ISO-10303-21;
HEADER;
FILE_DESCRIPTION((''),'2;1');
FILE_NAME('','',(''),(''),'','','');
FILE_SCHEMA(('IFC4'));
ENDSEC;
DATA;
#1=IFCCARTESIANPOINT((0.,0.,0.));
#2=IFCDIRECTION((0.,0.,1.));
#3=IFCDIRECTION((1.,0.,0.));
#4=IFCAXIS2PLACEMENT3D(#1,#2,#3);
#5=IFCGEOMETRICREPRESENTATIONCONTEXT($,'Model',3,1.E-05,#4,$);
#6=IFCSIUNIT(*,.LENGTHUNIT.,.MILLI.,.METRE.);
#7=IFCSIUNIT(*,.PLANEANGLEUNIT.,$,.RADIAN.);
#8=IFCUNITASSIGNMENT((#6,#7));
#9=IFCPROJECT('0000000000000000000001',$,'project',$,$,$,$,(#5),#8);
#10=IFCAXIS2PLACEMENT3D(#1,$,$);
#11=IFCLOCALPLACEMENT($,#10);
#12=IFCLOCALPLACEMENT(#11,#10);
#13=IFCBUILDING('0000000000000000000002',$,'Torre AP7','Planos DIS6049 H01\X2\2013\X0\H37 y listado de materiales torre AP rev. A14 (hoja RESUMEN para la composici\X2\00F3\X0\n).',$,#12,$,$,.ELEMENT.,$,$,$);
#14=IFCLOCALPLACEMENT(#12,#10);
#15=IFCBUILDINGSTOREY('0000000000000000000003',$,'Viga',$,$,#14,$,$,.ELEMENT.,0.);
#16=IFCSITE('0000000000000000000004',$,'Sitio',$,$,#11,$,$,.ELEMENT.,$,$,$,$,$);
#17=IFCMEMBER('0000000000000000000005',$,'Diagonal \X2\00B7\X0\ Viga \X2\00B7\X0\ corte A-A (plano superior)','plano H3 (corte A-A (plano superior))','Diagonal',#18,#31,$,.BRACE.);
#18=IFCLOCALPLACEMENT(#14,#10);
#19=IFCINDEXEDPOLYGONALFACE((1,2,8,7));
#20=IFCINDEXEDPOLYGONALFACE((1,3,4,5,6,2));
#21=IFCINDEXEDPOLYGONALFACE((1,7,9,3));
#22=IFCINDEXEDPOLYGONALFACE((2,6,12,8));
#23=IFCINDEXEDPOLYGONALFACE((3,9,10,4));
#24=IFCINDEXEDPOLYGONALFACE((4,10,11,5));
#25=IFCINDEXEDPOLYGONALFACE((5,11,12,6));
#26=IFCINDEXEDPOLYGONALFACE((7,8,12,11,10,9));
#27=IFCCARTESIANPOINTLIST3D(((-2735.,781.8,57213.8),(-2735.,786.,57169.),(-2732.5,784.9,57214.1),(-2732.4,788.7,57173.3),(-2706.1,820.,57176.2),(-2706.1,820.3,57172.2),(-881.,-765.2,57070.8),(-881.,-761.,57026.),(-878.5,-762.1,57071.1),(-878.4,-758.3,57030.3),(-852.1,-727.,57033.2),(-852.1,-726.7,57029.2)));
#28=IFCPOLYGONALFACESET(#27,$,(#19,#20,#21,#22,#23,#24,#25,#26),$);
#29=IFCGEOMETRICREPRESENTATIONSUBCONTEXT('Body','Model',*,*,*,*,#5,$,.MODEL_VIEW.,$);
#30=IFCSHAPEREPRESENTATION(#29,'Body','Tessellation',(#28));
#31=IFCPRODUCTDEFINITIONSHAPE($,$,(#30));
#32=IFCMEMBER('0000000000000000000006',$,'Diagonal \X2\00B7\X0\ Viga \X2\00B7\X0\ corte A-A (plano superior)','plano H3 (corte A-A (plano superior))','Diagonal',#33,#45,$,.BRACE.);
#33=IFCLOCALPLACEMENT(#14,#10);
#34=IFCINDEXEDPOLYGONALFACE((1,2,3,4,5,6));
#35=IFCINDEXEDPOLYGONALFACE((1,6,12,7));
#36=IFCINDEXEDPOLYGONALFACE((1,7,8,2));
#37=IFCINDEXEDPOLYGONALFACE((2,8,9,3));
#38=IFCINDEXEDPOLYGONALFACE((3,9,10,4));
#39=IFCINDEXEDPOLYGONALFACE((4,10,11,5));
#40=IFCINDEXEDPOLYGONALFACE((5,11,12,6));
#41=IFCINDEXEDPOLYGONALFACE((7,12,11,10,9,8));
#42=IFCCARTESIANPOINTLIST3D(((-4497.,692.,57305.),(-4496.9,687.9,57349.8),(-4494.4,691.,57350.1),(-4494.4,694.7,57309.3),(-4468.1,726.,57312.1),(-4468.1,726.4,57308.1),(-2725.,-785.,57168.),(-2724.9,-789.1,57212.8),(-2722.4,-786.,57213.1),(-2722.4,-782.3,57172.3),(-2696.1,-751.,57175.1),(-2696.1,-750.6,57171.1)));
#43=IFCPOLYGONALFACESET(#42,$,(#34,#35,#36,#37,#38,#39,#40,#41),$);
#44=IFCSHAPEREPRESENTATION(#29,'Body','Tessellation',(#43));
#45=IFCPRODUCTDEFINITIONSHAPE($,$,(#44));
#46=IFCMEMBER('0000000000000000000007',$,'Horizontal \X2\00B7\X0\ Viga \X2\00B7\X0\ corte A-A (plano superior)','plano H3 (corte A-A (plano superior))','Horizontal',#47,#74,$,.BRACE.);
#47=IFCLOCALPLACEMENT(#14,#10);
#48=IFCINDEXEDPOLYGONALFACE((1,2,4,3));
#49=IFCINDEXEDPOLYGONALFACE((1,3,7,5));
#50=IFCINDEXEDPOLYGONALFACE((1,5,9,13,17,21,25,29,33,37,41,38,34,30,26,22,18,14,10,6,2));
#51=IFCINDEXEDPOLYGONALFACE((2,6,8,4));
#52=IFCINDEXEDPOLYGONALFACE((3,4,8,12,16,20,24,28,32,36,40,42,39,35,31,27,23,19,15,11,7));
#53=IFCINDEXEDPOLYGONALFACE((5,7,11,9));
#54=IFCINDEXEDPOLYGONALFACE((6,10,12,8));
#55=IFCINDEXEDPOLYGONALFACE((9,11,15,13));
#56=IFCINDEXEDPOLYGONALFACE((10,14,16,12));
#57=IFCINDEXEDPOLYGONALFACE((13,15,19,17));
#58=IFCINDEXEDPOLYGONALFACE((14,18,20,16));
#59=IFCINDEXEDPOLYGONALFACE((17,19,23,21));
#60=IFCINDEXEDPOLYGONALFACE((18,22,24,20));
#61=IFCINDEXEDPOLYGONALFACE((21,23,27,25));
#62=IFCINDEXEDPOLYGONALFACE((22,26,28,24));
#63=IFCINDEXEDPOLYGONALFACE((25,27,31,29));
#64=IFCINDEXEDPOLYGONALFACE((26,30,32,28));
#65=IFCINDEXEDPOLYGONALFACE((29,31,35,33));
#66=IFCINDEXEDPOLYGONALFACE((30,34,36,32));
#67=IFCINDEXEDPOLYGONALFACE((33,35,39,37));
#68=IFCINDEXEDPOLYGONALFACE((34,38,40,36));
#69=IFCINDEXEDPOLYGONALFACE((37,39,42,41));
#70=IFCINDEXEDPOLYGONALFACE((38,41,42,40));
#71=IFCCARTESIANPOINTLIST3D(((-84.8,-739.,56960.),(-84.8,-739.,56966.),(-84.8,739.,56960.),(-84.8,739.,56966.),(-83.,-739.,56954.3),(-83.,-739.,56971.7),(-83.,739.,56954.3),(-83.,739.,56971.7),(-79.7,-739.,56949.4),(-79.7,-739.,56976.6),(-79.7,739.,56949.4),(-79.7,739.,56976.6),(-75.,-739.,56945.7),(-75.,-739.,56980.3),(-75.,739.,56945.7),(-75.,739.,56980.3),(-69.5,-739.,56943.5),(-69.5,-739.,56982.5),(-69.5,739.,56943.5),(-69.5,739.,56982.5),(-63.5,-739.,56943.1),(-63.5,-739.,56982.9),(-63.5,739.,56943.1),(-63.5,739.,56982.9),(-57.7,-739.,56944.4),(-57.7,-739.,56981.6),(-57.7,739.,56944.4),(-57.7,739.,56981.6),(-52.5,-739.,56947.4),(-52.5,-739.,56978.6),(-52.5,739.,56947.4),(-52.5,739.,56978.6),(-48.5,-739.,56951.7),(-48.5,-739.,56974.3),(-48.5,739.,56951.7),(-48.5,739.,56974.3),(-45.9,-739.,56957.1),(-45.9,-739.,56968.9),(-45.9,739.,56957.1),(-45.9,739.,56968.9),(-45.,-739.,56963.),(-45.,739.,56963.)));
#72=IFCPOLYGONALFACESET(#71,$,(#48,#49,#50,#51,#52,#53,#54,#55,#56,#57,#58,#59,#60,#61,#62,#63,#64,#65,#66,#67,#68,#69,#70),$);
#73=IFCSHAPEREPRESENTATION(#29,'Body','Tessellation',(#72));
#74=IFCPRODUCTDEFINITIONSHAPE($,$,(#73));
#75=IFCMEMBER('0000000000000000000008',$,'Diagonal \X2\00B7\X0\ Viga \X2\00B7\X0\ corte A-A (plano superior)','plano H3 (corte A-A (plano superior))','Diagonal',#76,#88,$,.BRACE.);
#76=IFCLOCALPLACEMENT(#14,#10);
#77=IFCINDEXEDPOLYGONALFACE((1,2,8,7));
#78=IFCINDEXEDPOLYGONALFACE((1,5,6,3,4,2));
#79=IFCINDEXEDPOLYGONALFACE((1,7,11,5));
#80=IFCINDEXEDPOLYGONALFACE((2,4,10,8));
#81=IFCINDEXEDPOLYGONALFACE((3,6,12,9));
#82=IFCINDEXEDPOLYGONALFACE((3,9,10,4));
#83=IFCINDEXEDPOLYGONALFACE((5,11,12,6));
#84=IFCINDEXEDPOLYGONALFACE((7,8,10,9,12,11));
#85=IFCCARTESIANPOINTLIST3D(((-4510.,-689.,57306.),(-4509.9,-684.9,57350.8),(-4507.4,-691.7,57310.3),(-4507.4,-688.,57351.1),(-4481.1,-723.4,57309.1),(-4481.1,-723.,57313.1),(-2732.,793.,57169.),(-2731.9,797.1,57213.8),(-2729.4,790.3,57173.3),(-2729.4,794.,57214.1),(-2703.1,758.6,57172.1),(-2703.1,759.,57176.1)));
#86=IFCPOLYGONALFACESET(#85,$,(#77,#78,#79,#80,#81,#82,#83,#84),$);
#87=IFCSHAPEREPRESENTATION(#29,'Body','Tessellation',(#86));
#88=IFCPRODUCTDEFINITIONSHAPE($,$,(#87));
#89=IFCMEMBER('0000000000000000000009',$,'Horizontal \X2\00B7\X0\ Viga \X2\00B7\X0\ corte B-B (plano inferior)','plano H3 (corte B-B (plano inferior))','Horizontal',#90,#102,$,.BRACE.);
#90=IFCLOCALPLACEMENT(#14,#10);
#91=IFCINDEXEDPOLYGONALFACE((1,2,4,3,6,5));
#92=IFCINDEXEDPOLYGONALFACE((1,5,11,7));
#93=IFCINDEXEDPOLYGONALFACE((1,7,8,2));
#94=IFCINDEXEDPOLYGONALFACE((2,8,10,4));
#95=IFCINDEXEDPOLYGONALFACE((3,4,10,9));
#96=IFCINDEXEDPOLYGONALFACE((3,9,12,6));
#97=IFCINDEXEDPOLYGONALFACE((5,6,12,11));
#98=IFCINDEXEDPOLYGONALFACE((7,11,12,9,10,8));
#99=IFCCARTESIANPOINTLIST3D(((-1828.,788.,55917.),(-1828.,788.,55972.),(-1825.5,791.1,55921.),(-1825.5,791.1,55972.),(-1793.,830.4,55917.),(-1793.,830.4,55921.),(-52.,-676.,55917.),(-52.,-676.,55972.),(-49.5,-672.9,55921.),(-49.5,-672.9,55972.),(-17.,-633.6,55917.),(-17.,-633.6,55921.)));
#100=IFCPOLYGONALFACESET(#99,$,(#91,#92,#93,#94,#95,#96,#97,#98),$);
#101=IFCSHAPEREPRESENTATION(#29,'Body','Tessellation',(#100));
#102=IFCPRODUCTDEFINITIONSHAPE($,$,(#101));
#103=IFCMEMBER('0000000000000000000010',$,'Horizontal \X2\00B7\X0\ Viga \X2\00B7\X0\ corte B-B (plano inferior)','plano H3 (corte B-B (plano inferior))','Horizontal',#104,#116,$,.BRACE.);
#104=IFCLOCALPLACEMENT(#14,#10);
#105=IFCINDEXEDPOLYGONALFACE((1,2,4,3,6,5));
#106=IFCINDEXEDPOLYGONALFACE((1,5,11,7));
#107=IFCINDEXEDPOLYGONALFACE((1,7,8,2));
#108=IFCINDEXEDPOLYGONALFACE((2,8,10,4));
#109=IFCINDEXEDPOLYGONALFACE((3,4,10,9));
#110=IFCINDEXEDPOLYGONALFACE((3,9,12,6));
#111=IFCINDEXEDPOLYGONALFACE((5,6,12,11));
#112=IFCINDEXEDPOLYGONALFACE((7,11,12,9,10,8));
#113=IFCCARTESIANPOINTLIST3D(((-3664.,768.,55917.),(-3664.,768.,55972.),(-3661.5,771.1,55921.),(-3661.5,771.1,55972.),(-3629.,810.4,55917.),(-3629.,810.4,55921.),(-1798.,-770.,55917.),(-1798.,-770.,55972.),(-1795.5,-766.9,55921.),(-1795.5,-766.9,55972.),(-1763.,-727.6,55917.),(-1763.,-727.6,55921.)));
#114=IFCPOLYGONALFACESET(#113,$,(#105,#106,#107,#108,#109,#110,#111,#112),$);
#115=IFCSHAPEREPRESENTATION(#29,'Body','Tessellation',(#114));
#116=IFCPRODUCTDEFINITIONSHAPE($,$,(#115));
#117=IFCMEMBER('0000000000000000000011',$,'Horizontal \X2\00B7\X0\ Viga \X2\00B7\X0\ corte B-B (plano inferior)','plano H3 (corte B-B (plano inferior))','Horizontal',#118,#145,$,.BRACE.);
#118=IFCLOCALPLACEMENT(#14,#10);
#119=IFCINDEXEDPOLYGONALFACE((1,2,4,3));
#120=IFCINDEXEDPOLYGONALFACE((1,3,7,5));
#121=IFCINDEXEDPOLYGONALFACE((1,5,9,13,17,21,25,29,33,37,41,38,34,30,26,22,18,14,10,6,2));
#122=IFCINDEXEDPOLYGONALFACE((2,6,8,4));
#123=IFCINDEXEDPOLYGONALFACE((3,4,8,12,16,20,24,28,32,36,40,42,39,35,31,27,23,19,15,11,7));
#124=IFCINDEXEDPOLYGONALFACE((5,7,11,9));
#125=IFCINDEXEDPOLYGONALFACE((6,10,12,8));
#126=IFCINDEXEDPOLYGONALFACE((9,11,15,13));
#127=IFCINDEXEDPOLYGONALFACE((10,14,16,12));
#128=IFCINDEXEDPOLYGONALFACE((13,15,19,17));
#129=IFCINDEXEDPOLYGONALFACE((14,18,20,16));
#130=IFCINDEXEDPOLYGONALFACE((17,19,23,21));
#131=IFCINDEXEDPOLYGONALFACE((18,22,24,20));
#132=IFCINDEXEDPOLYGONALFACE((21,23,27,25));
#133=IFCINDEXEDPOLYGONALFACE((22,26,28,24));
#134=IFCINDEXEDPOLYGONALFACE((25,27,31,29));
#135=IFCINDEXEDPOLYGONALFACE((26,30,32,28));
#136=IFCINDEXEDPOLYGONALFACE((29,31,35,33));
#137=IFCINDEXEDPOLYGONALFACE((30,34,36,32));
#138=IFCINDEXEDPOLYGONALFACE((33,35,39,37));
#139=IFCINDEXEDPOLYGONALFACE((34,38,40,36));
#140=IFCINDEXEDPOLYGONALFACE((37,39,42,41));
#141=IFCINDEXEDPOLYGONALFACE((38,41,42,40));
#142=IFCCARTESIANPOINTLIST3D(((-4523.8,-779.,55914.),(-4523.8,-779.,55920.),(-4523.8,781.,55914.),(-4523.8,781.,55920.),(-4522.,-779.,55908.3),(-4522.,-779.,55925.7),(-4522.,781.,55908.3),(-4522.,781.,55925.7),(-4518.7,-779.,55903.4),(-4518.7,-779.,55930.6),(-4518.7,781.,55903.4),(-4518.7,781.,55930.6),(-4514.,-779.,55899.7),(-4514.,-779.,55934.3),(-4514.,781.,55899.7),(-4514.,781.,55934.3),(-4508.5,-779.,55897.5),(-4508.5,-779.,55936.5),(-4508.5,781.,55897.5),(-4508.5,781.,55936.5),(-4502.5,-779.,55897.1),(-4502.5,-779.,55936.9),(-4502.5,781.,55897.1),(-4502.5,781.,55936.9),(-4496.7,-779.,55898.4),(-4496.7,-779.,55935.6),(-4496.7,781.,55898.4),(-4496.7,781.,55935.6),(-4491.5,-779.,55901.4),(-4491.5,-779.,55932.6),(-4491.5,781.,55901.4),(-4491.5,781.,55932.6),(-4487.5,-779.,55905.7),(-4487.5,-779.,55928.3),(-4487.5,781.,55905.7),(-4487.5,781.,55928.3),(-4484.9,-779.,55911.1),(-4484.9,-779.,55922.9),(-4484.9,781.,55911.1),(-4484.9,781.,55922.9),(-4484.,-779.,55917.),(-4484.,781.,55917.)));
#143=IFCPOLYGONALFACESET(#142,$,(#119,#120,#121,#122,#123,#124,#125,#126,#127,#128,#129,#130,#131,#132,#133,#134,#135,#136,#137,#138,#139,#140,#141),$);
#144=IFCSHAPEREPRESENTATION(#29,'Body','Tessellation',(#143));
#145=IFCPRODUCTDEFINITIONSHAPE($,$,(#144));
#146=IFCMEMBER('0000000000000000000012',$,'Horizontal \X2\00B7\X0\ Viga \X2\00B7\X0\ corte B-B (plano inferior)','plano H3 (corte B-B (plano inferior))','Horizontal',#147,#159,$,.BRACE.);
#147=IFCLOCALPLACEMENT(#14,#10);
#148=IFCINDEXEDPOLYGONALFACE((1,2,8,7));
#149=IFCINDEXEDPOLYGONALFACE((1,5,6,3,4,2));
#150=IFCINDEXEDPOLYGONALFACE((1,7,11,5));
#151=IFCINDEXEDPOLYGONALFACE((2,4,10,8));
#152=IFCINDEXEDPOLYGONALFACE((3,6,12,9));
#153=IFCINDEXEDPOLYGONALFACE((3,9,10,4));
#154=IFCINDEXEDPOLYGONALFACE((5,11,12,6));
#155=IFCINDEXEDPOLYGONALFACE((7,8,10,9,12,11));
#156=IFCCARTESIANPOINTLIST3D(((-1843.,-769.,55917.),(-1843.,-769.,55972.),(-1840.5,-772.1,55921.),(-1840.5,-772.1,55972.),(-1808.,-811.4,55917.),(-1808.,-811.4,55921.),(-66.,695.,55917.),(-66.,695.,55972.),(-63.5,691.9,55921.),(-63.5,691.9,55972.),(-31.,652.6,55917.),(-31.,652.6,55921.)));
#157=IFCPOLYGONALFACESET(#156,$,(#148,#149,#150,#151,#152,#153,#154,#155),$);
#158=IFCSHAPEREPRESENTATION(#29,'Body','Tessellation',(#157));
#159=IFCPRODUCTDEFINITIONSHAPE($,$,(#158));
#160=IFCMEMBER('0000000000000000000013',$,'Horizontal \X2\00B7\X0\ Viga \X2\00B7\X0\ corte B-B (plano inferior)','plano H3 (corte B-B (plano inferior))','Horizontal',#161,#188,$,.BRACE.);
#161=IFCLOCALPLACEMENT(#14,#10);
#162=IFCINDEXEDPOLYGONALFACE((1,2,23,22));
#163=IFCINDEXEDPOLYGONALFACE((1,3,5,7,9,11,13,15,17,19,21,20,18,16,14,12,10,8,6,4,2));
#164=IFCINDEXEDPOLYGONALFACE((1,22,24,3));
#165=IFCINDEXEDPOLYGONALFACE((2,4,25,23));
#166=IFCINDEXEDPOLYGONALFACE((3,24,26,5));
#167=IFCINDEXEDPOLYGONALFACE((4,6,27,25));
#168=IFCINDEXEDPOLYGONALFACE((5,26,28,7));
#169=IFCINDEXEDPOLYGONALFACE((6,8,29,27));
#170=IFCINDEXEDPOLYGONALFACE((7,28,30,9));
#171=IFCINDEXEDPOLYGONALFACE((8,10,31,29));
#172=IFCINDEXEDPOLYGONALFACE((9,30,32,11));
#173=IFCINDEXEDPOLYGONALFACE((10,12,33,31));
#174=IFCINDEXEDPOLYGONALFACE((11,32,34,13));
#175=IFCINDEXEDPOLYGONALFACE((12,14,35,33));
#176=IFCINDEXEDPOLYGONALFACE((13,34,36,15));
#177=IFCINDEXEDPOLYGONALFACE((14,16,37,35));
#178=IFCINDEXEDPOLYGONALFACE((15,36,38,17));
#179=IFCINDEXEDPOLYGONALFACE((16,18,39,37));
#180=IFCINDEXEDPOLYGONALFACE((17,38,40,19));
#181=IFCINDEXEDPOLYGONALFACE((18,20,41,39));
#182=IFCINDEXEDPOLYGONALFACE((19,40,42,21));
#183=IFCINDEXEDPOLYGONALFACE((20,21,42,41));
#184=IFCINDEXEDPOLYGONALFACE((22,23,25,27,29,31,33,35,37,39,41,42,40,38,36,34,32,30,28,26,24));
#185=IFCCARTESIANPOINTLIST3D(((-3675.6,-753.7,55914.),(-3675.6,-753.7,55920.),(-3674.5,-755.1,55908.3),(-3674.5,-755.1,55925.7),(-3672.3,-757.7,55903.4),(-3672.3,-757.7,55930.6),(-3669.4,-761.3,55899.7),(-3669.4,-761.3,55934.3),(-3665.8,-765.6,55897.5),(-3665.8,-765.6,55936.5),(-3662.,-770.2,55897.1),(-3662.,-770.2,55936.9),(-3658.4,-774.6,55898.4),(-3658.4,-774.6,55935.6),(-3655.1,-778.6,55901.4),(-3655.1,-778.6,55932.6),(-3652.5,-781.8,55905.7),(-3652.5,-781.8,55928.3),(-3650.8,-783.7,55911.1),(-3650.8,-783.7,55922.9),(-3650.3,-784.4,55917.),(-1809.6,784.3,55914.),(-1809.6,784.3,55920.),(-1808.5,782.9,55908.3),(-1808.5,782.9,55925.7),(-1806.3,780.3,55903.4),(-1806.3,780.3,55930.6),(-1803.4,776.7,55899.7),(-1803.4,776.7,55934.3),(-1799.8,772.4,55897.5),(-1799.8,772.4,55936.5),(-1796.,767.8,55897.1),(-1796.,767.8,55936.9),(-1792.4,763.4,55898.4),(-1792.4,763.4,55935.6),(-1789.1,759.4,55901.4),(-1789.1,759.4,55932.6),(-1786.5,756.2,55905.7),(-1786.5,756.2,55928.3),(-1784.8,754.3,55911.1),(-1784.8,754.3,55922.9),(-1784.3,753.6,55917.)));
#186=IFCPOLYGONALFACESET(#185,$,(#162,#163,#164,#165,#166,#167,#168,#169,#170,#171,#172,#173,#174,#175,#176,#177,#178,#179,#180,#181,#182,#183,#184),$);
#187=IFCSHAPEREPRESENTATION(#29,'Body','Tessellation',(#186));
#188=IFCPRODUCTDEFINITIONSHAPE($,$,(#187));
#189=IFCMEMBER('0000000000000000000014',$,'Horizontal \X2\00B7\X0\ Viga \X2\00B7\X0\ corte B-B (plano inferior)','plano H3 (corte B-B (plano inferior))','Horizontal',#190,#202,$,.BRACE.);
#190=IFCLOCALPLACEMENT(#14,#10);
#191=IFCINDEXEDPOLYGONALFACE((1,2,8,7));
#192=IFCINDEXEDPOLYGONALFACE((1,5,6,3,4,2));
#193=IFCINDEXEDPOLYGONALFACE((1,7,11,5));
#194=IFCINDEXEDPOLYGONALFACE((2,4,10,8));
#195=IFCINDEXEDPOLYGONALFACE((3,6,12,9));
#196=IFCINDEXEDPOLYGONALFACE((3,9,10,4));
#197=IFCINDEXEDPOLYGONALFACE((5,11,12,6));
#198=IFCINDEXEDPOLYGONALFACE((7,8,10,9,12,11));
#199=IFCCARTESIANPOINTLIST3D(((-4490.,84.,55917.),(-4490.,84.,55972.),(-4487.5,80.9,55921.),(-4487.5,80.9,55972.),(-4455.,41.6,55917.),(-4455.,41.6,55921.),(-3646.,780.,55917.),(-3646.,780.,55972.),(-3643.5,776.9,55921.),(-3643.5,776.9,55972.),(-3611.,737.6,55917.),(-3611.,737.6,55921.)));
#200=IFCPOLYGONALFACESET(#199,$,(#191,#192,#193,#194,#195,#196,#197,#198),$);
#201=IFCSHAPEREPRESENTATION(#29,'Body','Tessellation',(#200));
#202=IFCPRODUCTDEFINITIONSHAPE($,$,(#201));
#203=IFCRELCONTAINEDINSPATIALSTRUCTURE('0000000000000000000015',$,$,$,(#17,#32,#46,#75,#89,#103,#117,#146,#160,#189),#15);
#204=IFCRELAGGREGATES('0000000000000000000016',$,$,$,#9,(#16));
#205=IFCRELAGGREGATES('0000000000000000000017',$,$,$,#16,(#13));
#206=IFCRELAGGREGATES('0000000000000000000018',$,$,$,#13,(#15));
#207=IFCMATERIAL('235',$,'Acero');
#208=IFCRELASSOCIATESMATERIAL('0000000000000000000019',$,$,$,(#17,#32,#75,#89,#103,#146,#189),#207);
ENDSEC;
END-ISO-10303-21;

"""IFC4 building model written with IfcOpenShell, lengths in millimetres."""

from ifc_helpers import new_model, si_unit, frame, frame_2d, origin, origin_with_axes, place, context, subcontext, project, spatial, circle, l_section, extrude, material, element, save


model = new_model("IFC4")

# Units and contexts
model_context = context("Model", 3, precision=1e-05, world=origin_with_axes())
body_context = subcontext(model_context, "Body", "Model", "MODEL_VIEW")
ifc_project = project(units=[si_unit("LENGTHUNIT", "METRE", prefix="MILLI"), si_unit("PLANEANGLEUNIT", "RADIAN")], contexts=[model_context])

# Site, building, storey
site_placement = place(None, origin())
site = spatial("IfcSite", under=ifc_project, at=site_placement, Name="Sitio", CompositionType="ELEMENT")
building_placement = place(site_placement, origin())
building = spatial("IfcBuilding", under=site, at=building_placement, Name="Torre AP7", Description="Planos DIS6049 H01–H37 y listado de materiales torre AP rev. A14 (hoja RESUMEN para la composición).", CompositionType="ELEMENT")
storey_placement = place(building_placement, origin())
storey = spatial("IfcBuildingStorey", under=building, at=storey_placement, Name="Viga", CompositionType="ELEMENT", Elevation=0.0)

# Members
ifc_material = material(Name="235", Category="Acero")
member_1_placement = place(storey_placement, frame((-2735.0, 786.0, 57169.0), z_axis=(0.766471, -0.639553, -0.059118), x_axis=(0.642279, 0.763125, 0.071544)))
element("IfcMember", 1, at=member_1_placement, inside=storey, material=ifc_material, Name="Diagonal · Viga · corte A-A (plano superior)", Description="plano H3 (corte A-A (plano superior))", ObjectType="Diagonal", PredefinedType="BRACE", context=body_context, shape_type="SweptSolid", body=[
    extrude(l_section(Depth=45.0, Width=45.0, Thickness=4.0, at=frame_2d((22.5, 22.5))), None, (0.0, 0.0, 1.0), 2418.9),
])
member_2_placement = place(storey_placement, frame((-4497.0, 692.0, 57305.0), z_axis=(0.766799, -0.639144, -0.059284), x_axis=(0.641886, 0.763689, 0.069004)))
element("IfcMember", 2, at=member_2_placement, inside=storey, material=ifc_material, Name="Diagonal · Viga · corte A-A (plano superior)", Description="plano H3 (corte A-A (plano superior))", ObjectType="Diagonal", PredefinedType="BRACE", context=body_context, shape_type="SweptSolid", body=[
    extrude(l_section(Depth=45.0, Width=45.0, Thickness=4.0, at=frame_2d((22.5, 22.5))), None, (0.0, 0.0, 1.0), 2310.9),
])
member_3_placement = place(storey_placement, frame((-65.0, 739.0, 56963.0), z_axis=(0.0, -1.0, 0.0), x_axis=(1.0, 0.0, 0.0)))
element("IfcMember", 3, at=member_3_placement, inside=storey, Name="Horizontal · Viga · corte A-A (plano superior)", Description="plano H3 (corte A-A (plano superior))", ObjectType="Horizontal", PredefinedType="BRACE", context=body_context, shape_type="SweptSolid", body=[
    extrude(circle(Radius=20.0), None, (0.0, 0.0, 1.0), 1478.0),
])
member_4_placement = place(storey_placement, frame((-2732.0, 793.0, 57169.0), z_axis=(-0.766808, -0.639151, 0.059085), x_axis=(0.641875, -0.763738, 0.068568)))
element("IfcMember", 4, at=member_4_placement, inside=storey, material=ifc_material, Name="Diagonal · Viga · corte A-A (plano superior)", Description="plano H3 (corte A-A (plano superior))", ObjectType="Diagonal", PredefinedType="BRACE", context=body_context, shape_type="SweptSolid", body=[
    extrude(l_section(Depth=45.0, Width=45.0, Thickness=4.0, at=frame_2d((22.5, 22.5))), None, (0.0, 0.0, 1.0), 2318.7),
])
member_5_placement = place(storey_placement, frame((-1828.0, 788.0, 55917.0), z_axis=(0.771629, -0.636073, 0.0), x_axis=(0.636073, 0.771629, 0.0)))
element("IfcMember", 5, at=member_5_placement, inside=storey, material=ifc_material, Name="Horizontal · Viga · corte B-B (plano inferior)", Description="plano H3 (corte B-B (plano inferior))", ObjectType="Horizontal", PredefinedType="BRACE", context=body_context, shape_type="SweptSolid", body=[
    extrude(l_section(Depth=55.0, Width=55.0, Thickness=4.0, at=frame_2d((27.5, 27.5))), None, (0.0, 0.0, 1.0), 2301.6),
])
member_6_placement = place(storey_placement, frame((-3664.0, 768.0, 55917.0), z_axis=(0.771668, -0.636026, 0.0), x_axis=(0.636026, 0.771668, 0.0)))
element("IfcMember", 6, at=member_6_placement, inside=storey, material=ifc_material, Name="Horizontal · Viga · corte B-B (plano inferior)", Description="plano H3 (corte B-B (plano inferior))", ObjectType="Horizontal", PredefinedType="BRACE", context=body_context, shape_type="SweptSolid", body=[
    extrude(l_section(Depth=55.0, Width=55.0, Thickness=4.0, at=frame_2d((27.5, 27.5))), None, (0.0, 0.0, 1.0), 2418.1),
])
member_7_placement = place(storey_placement, frame((-4504.0, 781.0, 55917.0), z_axis=(0.0, -1.0, 0.0), x_axis=(1.0, 0.0, 0.0)))
element("IfcMember", 7, at=member_7_placement, inside=storey, Name="Horizontal · Viga · corte B-B (plano inferior)", Description="plano H3 (corte B-B (plano inferior))", ObjectType="Horizontal", PredefinedType="BRACE", context=body_context, shape_type="SweptSolid", body=[
    extrude(circle(Radius=20.0), None, (0.0, 0.0, 1.0), 1560.0),
])
member_8_placement = place(storey_placement, frame((-66.0, 695.0, 55917.0), z_axis=(-0.771805, -0.635859, 0.0), x_axis=(0.635859, -0.771805, 0.0)))
element("IfcMember", 8, at=member_8_placement, inside=storey, material=ifc_material, Name="Horizontal · Viga · corte B-B (plano inferior)", Description="plano H3 (corte B-B (plano inferior))", ObjectType="Horizontal", PredefinedType="BRACE", context=body_context, shape_type="SweptSolid", body=[
    extrude(l_section(Depth=55.0, Width=55.0, Thickness=4.0, at=frame_2d((27.5, 27.5))), None, (0.0, 0.0, 1.0), 2302.4),
])
member_9_placement = place(storey_placement, frame((-1797.0, 769.0, 55917.0), z_axis=(-0.771668, -0.636026, 0.0), x_axis=(0.636026, -0.771668, 0.0)))
element("IfcMember", 9, at=member_9_placement, inside=storey, Name="Horizontal · Viga · corte B-B (plano inferior)", Description="plano H3 (corte B-B (plano inferior))", ObjectType="Horizontal", PredefinedType="BRACE", context=body_context, shape_type="SweptSolid", body=[
    extrude(circle(Radius=20.0), None, (0.0, 0.0, 1.0), 2418.1),
])
member_10_placement = place(storey_placement, frame((-3646.0, 780.0, 55917.0), z_axis=(-0.771508, -0.63622, 0.0), x_axis=(0.63622, -0.771508, 0.0)))
element("IfcMember", 10, at=member_10_placement, inside=storey, material=ifc_material, Name="Horizontal · Viga · corte B-B (plano inferior)", Description="plano H3 (corte B-B (plano inferior))", ObjectType="Horizontal", PredefinedType="BRACE", context=body_context, shape_type="SweptSolid", body=[
    extrude(l_section(Depth=55.0, Width=55.0, Thickness=4.0, at=frame_2d((27.5, 27.5))), None, (0.0, 0.0, 1.0), 1094.0),
])

save(model, "model.ifc")
